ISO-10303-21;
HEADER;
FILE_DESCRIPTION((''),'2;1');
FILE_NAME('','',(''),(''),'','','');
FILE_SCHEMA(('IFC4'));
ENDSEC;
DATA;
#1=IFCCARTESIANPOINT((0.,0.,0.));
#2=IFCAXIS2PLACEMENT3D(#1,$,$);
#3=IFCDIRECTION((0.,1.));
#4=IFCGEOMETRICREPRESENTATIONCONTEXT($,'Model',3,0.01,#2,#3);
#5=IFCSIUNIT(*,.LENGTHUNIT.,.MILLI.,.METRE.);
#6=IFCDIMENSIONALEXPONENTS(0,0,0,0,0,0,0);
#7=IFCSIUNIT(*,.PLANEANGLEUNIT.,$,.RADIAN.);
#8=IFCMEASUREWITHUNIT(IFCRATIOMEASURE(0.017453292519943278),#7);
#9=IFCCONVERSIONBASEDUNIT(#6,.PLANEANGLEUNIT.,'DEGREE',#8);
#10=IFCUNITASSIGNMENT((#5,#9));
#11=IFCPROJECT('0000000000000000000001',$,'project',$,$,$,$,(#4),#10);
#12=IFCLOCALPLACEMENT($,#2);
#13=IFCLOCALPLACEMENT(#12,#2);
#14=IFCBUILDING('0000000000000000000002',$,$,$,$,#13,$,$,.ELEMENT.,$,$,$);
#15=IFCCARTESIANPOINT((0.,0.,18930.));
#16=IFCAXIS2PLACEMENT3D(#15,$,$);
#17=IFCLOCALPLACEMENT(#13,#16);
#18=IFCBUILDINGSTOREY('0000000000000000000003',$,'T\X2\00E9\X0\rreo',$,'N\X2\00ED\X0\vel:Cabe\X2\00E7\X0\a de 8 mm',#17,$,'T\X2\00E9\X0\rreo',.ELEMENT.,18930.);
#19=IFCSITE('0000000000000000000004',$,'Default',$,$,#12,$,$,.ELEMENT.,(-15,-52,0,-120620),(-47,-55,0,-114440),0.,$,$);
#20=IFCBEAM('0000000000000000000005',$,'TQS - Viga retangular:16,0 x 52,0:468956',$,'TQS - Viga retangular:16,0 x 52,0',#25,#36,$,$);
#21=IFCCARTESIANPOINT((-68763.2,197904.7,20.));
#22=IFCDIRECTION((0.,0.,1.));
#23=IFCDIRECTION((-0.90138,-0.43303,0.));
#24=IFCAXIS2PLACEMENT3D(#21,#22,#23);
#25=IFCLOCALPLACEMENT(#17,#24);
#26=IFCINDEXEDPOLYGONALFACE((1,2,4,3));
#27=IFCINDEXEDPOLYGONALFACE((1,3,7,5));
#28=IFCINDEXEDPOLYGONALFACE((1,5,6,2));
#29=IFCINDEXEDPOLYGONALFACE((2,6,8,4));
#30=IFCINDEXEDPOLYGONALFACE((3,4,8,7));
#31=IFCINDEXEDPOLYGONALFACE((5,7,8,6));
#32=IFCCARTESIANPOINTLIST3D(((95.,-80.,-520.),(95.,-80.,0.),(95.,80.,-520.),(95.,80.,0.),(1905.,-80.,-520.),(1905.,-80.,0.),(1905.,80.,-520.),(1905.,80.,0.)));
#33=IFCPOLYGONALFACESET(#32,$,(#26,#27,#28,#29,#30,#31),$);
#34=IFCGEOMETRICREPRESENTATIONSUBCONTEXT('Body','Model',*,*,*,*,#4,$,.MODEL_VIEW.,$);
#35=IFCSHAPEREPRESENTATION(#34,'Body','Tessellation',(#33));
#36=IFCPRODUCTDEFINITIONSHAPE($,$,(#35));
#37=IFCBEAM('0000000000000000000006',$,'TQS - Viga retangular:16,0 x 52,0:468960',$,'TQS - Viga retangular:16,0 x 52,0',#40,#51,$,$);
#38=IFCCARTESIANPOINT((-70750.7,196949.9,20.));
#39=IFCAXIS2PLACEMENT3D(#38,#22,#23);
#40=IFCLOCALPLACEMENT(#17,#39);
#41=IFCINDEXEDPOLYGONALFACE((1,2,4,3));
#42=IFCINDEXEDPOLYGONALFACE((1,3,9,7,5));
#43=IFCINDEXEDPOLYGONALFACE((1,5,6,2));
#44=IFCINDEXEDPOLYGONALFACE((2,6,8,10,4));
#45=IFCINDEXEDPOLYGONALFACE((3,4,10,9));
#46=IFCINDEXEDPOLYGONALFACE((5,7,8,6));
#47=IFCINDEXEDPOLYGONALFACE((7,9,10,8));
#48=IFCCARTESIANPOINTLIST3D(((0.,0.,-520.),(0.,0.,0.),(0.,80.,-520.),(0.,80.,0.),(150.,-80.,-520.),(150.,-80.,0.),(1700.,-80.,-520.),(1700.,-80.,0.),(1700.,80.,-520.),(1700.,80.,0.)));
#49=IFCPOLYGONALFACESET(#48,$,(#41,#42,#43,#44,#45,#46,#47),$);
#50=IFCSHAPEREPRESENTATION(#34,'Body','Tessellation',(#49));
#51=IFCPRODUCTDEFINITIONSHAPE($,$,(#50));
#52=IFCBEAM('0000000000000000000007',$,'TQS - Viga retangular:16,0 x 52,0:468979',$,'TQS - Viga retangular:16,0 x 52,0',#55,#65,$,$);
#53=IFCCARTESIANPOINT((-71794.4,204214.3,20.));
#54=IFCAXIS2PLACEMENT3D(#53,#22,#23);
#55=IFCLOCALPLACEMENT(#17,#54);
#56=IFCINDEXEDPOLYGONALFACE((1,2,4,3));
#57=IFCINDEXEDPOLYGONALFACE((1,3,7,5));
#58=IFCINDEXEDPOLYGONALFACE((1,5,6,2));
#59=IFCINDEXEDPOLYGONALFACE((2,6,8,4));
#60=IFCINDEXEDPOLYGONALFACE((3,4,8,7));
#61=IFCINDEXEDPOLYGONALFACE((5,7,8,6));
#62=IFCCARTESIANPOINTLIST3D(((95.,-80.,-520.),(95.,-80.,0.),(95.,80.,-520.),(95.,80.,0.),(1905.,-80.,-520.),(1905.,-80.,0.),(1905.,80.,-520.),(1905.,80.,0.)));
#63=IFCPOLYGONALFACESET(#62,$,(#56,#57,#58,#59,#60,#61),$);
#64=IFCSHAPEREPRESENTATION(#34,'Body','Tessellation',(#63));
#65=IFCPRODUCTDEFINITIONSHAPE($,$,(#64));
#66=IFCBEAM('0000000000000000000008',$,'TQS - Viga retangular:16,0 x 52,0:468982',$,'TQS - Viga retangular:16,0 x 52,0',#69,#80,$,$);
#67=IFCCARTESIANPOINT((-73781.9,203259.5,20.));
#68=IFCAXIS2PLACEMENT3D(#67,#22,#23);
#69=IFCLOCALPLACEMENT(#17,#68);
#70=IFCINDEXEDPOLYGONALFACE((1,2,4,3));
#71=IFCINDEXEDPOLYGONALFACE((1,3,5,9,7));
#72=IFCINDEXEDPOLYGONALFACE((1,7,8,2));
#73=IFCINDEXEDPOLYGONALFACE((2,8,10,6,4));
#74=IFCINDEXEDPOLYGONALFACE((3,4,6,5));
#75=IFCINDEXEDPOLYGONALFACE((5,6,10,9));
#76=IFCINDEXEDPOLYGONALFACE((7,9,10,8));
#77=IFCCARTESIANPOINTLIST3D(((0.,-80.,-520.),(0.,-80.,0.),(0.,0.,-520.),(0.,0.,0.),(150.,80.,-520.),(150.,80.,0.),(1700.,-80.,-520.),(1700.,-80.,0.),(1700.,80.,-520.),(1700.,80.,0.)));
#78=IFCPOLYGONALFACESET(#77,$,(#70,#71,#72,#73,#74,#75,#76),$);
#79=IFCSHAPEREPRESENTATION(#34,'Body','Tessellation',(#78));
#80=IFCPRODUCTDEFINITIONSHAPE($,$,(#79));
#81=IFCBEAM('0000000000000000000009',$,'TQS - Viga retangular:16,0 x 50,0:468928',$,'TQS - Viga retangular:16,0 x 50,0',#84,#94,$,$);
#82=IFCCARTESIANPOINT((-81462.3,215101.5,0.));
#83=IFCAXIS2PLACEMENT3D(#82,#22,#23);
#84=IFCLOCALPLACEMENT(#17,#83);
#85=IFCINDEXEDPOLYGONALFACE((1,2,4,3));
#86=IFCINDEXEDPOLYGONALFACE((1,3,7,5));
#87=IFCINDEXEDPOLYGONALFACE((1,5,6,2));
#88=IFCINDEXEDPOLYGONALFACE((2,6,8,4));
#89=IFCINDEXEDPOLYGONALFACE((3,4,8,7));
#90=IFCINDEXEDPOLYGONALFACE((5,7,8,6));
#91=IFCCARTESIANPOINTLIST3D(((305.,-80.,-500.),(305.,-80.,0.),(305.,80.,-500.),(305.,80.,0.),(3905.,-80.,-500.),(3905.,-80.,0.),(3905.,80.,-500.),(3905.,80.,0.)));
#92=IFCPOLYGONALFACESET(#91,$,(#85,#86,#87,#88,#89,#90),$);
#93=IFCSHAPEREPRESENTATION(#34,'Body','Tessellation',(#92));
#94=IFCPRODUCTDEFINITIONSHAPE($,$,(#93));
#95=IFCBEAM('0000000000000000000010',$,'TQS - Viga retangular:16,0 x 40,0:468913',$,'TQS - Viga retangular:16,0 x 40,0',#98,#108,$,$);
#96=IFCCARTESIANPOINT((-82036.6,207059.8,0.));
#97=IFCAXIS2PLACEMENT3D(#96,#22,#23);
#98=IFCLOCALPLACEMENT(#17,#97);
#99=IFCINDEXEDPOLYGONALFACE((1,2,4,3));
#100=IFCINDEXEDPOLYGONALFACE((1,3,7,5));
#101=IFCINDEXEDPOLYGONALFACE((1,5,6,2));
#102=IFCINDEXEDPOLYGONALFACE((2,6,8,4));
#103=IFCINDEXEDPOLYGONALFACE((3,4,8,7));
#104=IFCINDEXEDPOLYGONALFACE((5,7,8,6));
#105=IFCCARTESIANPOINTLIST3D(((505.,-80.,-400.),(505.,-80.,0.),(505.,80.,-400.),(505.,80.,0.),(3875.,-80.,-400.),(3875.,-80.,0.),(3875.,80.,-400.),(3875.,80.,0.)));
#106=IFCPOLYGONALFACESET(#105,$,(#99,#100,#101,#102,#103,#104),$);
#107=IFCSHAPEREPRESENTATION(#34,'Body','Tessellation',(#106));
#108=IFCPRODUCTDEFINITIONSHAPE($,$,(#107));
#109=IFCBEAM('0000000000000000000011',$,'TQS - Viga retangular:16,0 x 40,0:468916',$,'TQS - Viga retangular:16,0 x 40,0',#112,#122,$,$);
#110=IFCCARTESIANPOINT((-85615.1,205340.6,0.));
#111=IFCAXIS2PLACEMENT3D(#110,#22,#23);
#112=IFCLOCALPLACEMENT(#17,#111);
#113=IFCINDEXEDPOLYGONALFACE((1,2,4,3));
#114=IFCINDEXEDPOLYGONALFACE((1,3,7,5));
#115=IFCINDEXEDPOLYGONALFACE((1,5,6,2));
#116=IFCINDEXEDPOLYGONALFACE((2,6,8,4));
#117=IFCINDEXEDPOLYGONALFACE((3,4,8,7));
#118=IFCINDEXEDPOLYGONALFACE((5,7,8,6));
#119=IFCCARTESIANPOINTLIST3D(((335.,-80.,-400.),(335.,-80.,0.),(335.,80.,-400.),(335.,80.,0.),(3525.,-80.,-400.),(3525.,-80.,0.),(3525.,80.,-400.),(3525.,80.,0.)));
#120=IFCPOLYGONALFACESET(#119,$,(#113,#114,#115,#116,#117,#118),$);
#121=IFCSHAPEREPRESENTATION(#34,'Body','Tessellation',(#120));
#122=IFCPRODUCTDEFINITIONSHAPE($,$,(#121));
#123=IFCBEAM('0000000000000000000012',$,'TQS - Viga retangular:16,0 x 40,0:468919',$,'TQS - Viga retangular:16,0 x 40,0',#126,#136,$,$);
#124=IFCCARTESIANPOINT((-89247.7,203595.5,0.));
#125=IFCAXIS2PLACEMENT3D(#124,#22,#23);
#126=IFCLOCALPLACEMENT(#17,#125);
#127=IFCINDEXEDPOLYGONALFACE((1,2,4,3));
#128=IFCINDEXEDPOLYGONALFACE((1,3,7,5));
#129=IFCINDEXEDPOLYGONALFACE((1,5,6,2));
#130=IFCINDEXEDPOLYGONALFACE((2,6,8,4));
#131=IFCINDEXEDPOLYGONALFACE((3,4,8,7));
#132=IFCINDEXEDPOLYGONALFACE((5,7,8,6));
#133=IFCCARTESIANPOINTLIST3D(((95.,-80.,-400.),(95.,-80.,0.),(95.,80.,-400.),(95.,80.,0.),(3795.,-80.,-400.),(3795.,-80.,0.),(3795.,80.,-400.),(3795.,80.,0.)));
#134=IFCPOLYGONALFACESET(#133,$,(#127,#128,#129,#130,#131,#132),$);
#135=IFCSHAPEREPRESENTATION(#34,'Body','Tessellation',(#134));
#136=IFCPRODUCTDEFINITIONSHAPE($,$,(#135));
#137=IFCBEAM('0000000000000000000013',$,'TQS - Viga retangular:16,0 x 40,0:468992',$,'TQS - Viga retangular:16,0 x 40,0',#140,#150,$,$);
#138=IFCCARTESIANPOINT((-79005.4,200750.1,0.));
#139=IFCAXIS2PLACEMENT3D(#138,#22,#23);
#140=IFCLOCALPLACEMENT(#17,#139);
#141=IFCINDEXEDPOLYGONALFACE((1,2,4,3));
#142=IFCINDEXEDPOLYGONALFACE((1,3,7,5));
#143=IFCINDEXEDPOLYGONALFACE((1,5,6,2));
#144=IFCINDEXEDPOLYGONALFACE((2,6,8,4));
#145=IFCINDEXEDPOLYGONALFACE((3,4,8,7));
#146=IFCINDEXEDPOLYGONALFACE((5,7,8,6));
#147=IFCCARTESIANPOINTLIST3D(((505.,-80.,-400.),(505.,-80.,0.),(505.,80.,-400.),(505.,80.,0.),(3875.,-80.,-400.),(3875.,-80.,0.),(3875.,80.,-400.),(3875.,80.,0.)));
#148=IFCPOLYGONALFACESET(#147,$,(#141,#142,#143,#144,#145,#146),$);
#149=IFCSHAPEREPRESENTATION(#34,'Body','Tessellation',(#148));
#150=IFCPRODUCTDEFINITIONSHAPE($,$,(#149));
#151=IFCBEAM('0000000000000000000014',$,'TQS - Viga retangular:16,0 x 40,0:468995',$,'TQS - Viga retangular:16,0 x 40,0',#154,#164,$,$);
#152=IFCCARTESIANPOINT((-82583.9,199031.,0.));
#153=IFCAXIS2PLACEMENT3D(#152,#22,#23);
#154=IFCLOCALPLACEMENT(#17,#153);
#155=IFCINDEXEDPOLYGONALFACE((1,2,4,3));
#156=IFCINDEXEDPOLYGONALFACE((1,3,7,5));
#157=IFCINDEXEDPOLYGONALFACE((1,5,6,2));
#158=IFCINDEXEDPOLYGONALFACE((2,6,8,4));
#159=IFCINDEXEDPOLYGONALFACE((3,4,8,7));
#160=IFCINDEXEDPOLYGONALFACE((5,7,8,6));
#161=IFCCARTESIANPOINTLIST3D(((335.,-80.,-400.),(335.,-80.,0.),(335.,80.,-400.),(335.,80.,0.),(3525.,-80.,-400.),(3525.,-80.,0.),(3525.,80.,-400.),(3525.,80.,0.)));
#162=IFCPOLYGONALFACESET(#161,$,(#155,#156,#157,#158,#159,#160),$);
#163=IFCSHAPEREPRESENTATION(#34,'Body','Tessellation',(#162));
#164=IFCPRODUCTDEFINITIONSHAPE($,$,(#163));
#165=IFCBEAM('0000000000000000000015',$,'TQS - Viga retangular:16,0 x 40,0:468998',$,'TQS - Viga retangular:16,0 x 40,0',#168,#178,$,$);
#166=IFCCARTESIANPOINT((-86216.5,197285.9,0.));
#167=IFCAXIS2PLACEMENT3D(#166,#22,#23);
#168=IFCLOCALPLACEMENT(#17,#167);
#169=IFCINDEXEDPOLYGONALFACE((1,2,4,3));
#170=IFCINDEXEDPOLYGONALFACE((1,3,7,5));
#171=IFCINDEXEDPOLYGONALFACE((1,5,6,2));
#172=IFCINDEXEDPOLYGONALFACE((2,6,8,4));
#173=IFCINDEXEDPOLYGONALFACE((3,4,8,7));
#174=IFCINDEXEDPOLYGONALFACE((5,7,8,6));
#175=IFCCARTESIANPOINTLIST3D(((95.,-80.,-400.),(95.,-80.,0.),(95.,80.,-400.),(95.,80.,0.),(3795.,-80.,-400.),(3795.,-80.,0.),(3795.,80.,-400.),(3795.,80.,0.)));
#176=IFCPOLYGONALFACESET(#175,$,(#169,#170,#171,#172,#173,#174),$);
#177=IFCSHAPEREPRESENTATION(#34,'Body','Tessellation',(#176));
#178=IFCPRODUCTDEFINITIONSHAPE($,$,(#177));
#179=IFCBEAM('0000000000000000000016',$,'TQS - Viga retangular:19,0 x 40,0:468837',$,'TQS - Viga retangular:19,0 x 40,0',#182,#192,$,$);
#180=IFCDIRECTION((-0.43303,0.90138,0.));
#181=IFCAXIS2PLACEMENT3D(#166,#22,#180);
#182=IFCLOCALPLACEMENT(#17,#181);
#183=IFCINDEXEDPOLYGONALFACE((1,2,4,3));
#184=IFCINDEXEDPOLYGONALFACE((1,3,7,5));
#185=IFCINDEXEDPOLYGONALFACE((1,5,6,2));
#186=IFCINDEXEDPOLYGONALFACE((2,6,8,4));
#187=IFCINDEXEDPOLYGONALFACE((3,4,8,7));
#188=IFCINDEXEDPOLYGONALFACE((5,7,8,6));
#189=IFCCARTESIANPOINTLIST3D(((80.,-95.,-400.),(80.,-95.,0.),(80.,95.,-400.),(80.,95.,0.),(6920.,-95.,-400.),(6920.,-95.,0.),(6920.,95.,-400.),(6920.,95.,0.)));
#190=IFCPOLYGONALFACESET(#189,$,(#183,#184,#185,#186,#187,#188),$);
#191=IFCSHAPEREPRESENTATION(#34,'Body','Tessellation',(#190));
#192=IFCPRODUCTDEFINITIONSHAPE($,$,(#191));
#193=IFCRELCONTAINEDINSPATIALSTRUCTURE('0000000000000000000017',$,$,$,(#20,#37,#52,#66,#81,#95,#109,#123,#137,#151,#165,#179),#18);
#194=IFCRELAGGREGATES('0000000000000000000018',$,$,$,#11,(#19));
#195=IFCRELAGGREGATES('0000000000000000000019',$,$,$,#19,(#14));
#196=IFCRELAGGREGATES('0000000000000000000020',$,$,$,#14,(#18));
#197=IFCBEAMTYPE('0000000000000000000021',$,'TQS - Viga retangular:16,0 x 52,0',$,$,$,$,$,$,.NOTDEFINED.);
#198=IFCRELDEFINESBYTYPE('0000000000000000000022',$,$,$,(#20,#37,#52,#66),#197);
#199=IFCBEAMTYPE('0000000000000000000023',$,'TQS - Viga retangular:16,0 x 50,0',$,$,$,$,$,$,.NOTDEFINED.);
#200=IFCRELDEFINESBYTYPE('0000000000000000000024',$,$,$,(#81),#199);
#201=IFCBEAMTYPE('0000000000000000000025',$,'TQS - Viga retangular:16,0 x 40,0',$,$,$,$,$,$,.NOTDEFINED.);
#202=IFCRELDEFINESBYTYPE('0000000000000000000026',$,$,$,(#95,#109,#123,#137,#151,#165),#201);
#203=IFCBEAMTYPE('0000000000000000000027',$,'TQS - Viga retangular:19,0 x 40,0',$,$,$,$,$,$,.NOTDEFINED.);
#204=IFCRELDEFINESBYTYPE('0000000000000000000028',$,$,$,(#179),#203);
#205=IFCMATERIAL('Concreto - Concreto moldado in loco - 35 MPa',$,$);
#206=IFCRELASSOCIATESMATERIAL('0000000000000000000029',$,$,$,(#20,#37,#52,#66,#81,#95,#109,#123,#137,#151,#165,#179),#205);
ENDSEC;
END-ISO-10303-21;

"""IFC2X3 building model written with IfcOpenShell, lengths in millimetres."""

from ifc_helpers import new_model, entity, si_unit, converted_unit, direction, frame, frame_2d, origin, origin_2d_with_axis, place, context, subcontext, project, spatial, rectangle, extrude, clip, halfspace, material, type_object, element, save


model = new_model("IFC2X3")

# Units and contexts
model_context = context("Model", 3, precision=0.01, world=origin(), true_north=direction((0.0, 1.0)))
body_context = subcontext(model_context, "Body", "Model", "MODEL_VIEW")
ifc_project = project(units=[si_unit("LENGTHUNIT", "METRE", prefix="MILLI"), converted_unit("PLANEANGLEUNIT", "DEGREE", entity("IfcRatioMeasure", 0.017453292519943278), si_unit("PLANEANGLEUNIT", "RADIAN"), dimensions=[0, 0, 0, 0, 0, 0, 0])], contexts=[model_context])

# Site, building, storey
site_placement = place(None, origin())
site = spatial("IfcSite", under=ifc_project, at=site_placement, Name="Default", CompositionType="ELEMENT", RefLatitude=(-15, -52, 0, -120620), RefLongitude=(-47, -55, 0, -114440), RefElevation=0.0)
building_placement = place(site_placement, origin())
building = spatial("IfcBuilding", under=site, at=building_placement, CompositionType="ELEMENT")
storey_placement = place(building_placement, frame((0.0, 0.0, 18930.0)))
storey = spatial("IfcBuildingStorey", under=building, at=storey_placement, Name="Térreo", ObjectType="Nível:Cabeça de 8 mm", LongName="Térreo", CompositionType="ELEMENT", Elevation=18930.0)

# Beams
ifc_material_1 = material(Name="Concreto - Concreto moldado in loco - 35 MPa")
beam_type_1 = type_object("IfcBeamType", Name="TQS - Viga retangular:16,0 x 52,0", PredefinedType="NOTDEFINED")
beam_1_placement = place(storey_placement, frame((-68763.2, 197904.7, 20.0), z_axis=(0.0, 0.0, 1.0), x_axis=(-0.90138, -0.43303, 0.0)))
element("IfcBeam", 1, at=beam_1_placement, inside=storey, type_object=beam_type_1, material=ifc_material_1, Name="TQS - Viga retangular:16,0 x 52,0:468956", ObjectType="TQS - Viga retangular:16,0 x 52,0", context=body_context, shape_type="SweptSolid", body=[
    extrude(rectangle(XDim=520.0, YDim=160.0, at=frame_2d((0.0, 0.0), x_axis=(1.0, 0.0))), frame((95.0, 0.0, -260.0), z_axis=(1.0, 0.0, 0.0), x_axis=(0.0, 0.0, -1.0)), (0.0, 0.0, 1.0), 1810.0),
])
beam_2_placement = place(storey_placement, frame((-70750.7, 196949.9, 20.0), z_axis=(0.0, 0.0, 1.0), x_axis=(-0.90138, -0.43303, 0.0)))
element("IfcBeam", 2, at=beam_2_placement, inside=storey, type_object=beam_type_1, material=ifc_material_1, Name="TQS - Viga retangular:16,0 x 52,0:468960", ObjectType="TQS - Viga retangular:16,0 x 52,0", context=body_context, shape_type="SweptSolid", body=[
    clip(extrude(rectangle(XDim=520.0, YDim=160.0, at=frame_2d((0.0, 0.0), x_axis=(1.0, 0.0))), frame((0.0, 0.0, -260.0), z_axis=(1.0, 0.0, 0.0), x_axis=(0.0, 0.0, -1.0)), (0.0, 0.0, 1.0), 1700.0), halfspace(frame((150.0, -80.0, 0.0), z_axis=(-0.470588, -0.882353, 0.0), x_axis=(-0.882353, 0.470588, 0.0)), False)),
])
beam_3_placement = place(storey_placement, frame((-71794.4, 204214.3, 20.0), z_axis=(0.0, 0.0, 1.0), x_axis=(-0.90138, -0.43303, 0.0)))
element("IfcBeam", 3, at=beam_3_placement, inside=storey, type_object=beam_type_1, material=ifc_material_1, Name="TQS - Viga retangular:16,0 x 52,0:468979", ObjectType="TQS - Viga retangular:16,0 x 52,0", context=body_context, shape_type="SweptSolid", body=[
    extrude(rectangle(XDim=520.0, YDim=160.0, at=frame_2d((0.0, 0.0), x_axis=(1.0, 0.0))), frame((95.0, 0.0, -260.0), z_axis=(1.0, 0.0, 0.0), x_axis=(0.0, 0.0, -1.0)), (0.0, 0.0, 1.0), 1810.0),
])
beam_4_placement = place(storey_placement, frame((-73781.9, 203259.5, 20.0), z_axis=(0.0, 0.0, 1.0), x_axis=(-0.90138, -0.43303, 0.0)))
element("IfcBeam", 4, at=beam_4_placement, inside=storey, type_object=beam_type_1, material=ifc_material_1, Name="TQS - Viga retangular:16,0 x 52,0:468982", ObjectType="TQS - Viga retangular:16,0 x 52,0", context=body_context, shape_type="SweptSolid", body=[
    clip(extrude(rectangle(XDim=520.0, YDim=160.0, at=frame_2d((0.0, 0.0), x_axis=(1.0, 0.0))), frame((0.0, 0.0, -260.0), z_axis=(1.0, 0.0, 0.0), x_axis=(0.0, 0.0, -1.0)), (0.0, 0.0, 1.0), 1700.0), halfspace(frame((150.0, 80.0, 0.0), z_axis=(-0.470588, 0.882353, 0.0), x_axis=(-0.882353, -0.470588, 0.0)), False)),
])
beam_type_2 = type_object("IfcBeamType", Name="TQS - Viga retangular:16,0 x 50,0", PredefinedType="NOTDEFINED")
beam_5_placement = place(storey_placement, frame((-81462.3, 215101.5, 0.0), z_axis=(0.0, 0.0, 1.0), x_axis=(-0.90138, -0.43303, 0.0)))
element("IfcBeam", 5, at=beam_5_placement, inside=storey, type_object=beam_type_2, material=ifc_material_1, Name="TQS - Viga retangular:16,0 x 50,0:468928", ObjectType="TQS - Viga retangular:16,0 x 50,0", context=body_context, shape_type="SweptSolid", body=[
    extrude(rectangle(XDim=500.0, YDim=160.0, at=frame_2d((0.0, 0.0), x_axis=(1.0, 0.0))), frame((305.0, 0.0, -250.0), z_axis=(1.0, 0.0, 0.0), x_axis=(0.0, 0.0, -1.0)), (0.0, 0.0, 1.0), 3600.0),
])
beam_type_3 = type_object("IfcBeamType", Name="TQS - Viga retangular:16,0 x 40,0", PredefinedType="NOTDEFINED")
beam_6_placement = place(storey_placement, frame((-82036.6, 207059.8, 0.0), z_axis=(0.0, 0.0, 1.0), x_axis=(-0.90138, -0.43303, 0.0)))
element("IfcBeam", 6, at=beam_6_placement, inside=storey, type_object=beam_type_3, material=ifc_material_1, Name="TQS - Viga retangular:16,0 x 40,0:468913", ObjectType="TQS - Viga retangular:16,0 x 40,0", context=body_context, shape_type="SweptSolid", body=[
    extrude(rectangle(XDim=400.0, YDim=160.0, at=frame_2d((0.0, 0.0), x_axis=(1.0, 0.0))), frame((505.0, 0.0, -200.0), z_axis=(1.0, 0.0, 0.0), x_axis=(0.0, 0.0, -1.0)), (0.0, 0.0, 1.0), 3370.0),
])
beam_7_placement = place(storey_placement, frame((-85615.1, 205340.6, 0.0), z_axis=(0.0, 0.0, 1.0), x_axis=(-0.90138, -0.43303, 0.0)))
element("IfcBeam", 7, at=beam_7_placement, inside=storey, type_object=beam_type_3, material=ifc_material_1, Name="TQS - Viga retangular:16,0 x 40,0:468916", ObjectType="TQS - Viga retangular:16,0 x 40,0", context=body_context, shape_type="SweptSolid", body=[
    extrude(rectangle(XDim=400.0, YDim=160.0, at=frame_2d((0.0, 0.0), x_axis=(1.0, 0.0))), frame((335.0, 0.0, -200.0), z_axis=(1.0, 0.0, 0.0), x_axis=(0.0, 0.0, -1.0)), (0.0, 0.0, 1.0), 3190.0),
])
beam_8_placement = place(storey_placement, frame((-89247.7, 203595.5, 0.0), z_axis=(0.0, 0.0, 1.0), x_axis=(-0.90138, -0.43303, 0.0)))
element("IfcBeam", 8, at=beam_8_placement, inside=storey, type_object=beam_type_3, material=ifc_material_1, Name="TQS - Viga retangular:16,0 x 40,0:468919", ObjectType="TQS - Viga retangular:16,0 x 40,0", context=body_context, shape_type="SweptSolid", body=[
    extrude(rectangle(XDim=400.0, YDim=160.0, at=frame_2d((0.0, 0.0), x_axis=(1.0, 0.0))), frame((95.0, 0.0, -200.0), z_axis=(1.0, 0.0, 0.0), x_axis=(0.0, 0.0, -1.0)), (0.0, 0.0, 1.0), 3700.0),
])
beam_9_placement = place(storey_placement, frame((-79005.4, 200750.1, 0.0), z_axis=(0.0, 0.0, 1.0), x_axis=(-0.90138, -0.43303, 0.0)))
element("IfcBeam", 9, at=beam_9_placement, inside=storey, type_object=beam_type_3, material=ifc_material_1, Name="TQS - Viga retangular:16,0 x 40,0:468992", ObjectType="TQS - Viga retangular:16,0 x 40,0", context=body_context, shape_type="SweptSolid", body=[
    extrude(rectangle(XDim=400.0, YDim=160.0, at=frame_2d((0.0, 0.0), x_axis=(1.0, 0.0))), frame((505.0, 0.0, -200.0), z_axis=(1.0, 0.0, 0.0), x_axis=(0.0, 0.0, -1.0)), (0.0, 0.0, 1.0), 3370.0),
])
beam_10_placement = place(storey_placement, frame((-82583.9, 199031.0, 0.0), z_axis=(0.0, 0.0, 1.0), x_axis=(-0.90138, -0.43303, 0.0)))
element("IfcBeam", 10, at=beam_10_placement, inside=storey, type_object=beam_type_3, material=ifc_material_1, Name="TQS - Viga retangular:16,0 x 40,0:468995", ObjectType="TQS - Viga retangular:16,0 x 40,0", context=body_context, shape_type="SweptSolid", body=[
    extrude(rectangle(XDim=400.0, YDim=160.0, at=frame_2d((0.0, 0.0), x_axis=(1.0, 0.0))), frame((335.0, 0.0, -200.0), z_axis=(1.0, 0.0, 0.0), x_axis=(0.0, 0.0, -1.0)), (0.0, 0.0, 1.0), 3190.0),
])
beam_11_placement = place(storey_placement, frame((-86216.5, 197285.9, 0.0), z_axis=(0.0, 0.0, 1.0), x_axis=(-0.90138, -0.43303, 0.0)))
element("IfcBeam", 11, at=beam_11_placement, inside=storey, type_object=beam_type_3, material=ifc_material_1, Name="TQS - Viga retangular:16,0 x 40,0:468998", ObjectType="TQS - Viga retangular:16,0 x 40,0", context=body_context, shape_type="SweptSolid", body=[
    extrude(rectangle(XDim=400.0, YDim=160.0, at=origin_2d_with_axis()), frame((95.0, 0.0, -200.0), z_axis=(1.0, 0.0, 0.0), x_axis=(0.0, 0.0, -1.0)), (0.0, 0.0, 1.0), 3700.0),
])
beam_type_4 = type_object("IfcBeamType", Name="TQS - Viga retangular:19,0 x 40,0", PredefinedType="NOTDEFINED")
beam_12_placement = place(storey_placement, frame((-86216.5, 197285.9, 0.0), z_axis=(0.0, 0.0, 1.0), x_axis=(-0.43303, 0.90138, 0.0)))
element("IfcBeam", 12, at=beam_12_placement, inside=storey, type_object=beam_type_4, material=ifc_material_1, Name="TQS - Viga retangular:19,0 x 40,0:468837", ObjectType="TQS - Viga retangular:19,0 x 40,0", context=body_context, shape_type="SweptSolid", body=[
    extrude(rectangle(XDim=400.0, YDim=190.0, at=origin_2d_with_axis()), frame((80.0, 0.0, -200.0), z_axis=(1.0, 0.0, 0.0), x_axis=(0.0, 0.0, -1.0)), (0.0, 0.0, 1.0), 6840.0),
])

save(model, "model.ifc")
